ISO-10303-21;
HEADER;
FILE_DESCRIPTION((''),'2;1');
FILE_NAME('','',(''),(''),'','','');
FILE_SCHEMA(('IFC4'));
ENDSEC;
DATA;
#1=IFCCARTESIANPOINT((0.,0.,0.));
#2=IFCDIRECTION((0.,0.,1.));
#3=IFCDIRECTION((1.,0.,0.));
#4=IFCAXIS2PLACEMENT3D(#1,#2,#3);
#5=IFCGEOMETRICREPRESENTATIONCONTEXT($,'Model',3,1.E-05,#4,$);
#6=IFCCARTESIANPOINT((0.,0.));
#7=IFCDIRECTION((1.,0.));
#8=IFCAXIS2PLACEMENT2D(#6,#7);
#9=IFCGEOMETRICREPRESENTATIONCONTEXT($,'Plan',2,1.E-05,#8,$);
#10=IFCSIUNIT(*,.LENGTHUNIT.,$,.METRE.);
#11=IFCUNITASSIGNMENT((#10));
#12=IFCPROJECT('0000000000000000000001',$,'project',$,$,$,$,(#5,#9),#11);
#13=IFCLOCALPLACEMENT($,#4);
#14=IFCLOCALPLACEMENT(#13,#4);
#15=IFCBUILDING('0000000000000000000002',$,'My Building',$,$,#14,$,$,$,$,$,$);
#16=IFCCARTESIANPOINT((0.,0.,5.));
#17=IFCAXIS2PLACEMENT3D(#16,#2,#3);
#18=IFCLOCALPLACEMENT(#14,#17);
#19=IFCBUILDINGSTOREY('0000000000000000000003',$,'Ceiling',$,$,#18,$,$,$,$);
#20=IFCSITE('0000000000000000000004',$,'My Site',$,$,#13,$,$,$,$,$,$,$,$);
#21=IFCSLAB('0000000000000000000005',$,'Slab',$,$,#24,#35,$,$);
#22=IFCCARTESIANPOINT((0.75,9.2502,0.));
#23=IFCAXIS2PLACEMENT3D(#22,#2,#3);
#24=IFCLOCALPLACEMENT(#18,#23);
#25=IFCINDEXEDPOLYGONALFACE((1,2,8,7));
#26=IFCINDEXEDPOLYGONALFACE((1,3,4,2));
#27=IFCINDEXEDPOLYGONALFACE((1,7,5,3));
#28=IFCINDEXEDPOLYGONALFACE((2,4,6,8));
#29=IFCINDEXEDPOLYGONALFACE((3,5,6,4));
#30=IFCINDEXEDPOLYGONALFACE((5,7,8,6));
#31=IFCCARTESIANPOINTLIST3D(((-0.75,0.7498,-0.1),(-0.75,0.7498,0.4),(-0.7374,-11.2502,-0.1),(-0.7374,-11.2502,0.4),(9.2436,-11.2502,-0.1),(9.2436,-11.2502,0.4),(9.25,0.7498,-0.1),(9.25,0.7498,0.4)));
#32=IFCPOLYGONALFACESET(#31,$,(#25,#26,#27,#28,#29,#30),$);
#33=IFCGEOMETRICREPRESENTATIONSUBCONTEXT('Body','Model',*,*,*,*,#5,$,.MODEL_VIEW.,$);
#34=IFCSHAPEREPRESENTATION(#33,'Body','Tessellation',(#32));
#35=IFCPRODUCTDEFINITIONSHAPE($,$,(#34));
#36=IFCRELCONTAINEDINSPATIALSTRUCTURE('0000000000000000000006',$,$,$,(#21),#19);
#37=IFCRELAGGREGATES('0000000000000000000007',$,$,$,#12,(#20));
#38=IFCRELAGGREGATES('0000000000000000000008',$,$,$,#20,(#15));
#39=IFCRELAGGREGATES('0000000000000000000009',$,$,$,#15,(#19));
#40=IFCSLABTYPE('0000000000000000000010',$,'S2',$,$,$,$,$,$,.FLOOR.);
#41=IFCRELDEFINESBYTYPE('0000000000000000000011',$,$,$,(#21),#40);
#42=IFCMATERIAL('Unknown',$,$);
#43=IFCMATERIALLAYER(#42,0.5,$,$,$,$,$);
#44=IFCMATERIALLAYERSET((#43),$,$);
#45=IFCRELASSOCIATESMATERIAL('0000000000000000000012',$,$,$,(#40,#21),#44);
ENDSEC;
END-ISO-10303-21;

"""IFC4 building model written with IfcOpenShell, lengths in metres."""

from ifc_helpers import new_model, si_unit, frame, origin_with_axes, origin_2d_with_axis, place, context, subcontext, project, spatial, indexed_curve, outline, extrude, material, layer, layer_set, layer_usage, type_object, element, save


model = new_model("IFC4")

# Units and contexts
model_context = context("Model", 3, precision=1e-05, world=origin_with_axes())
plan_context = context("Plan", 2, precision=1e-05, world=origin_2d_with_axis())
body_context = subcontext(model_context, "Body", "Model", "MODEL_VIEW")
ifc_project = project(units=[si_unit("LENGTHUNIT", "METRE")], contexts=[model_context, plan_context])

# Site, building, storey
site_placement = place(None, origin_with_axes())
site = spatial("IfcSite", under=ifc_project, at=site_placement, Name="My Site")
building_placement = place(site_placement, origin_with_axes())
building = spatial("IfcBuilding", under=site, at=building_placement, Name="My Building")
storey_placement = place(building_placement, frame((0.0, 0.0, 5.0), z_axis=(0.0, 0.0, 1.0), x_axis=(1.0, 0.0, 0.0)))
storey = spatial("IfcBuildingStorey", under=building, at=storey_placement, Name="Ceiling")

# Slab
ifc_material = material(Name="Unknown")
ifc_layer = layer(ifc_material, 0.5)
ifc_layer_set = layer_set([ifc_layer])
ifc_layer_usage = layer_usage(ifc_layer_set, "AXIS3", "POSITIVE", -0.1)
slab_type = type_object("IfcSlabType", Name="S2", PredefinedType="FLOOR", material=ifc_layer_set)
slab_placement = place(storey_placement, frame((0.75, 9.2502, 0.0), z_axis=(0.0, 0.0, 1.0), x_axis=(1.0, 0.0, 0.0)))
element("IfcSlab", 1, at=slab_placement, inside=storey, type_object=slab_type, material=ifc_layer_usage, Name="Slab", context=body_context, shape_type="SweptSolid", body=[
    extrude(outline(indexed_curve([(-0.7374, -11.2502), (9.2436, -11.2502), (9.25, 0.7498), (-0.75, 0.7498), (-0.7374, -11.2502)])), frame((0.0, 0.0, -0.1), z_axis=(0.0, 0.0, 1.0), x_axis=(1.0, 0.0, 0.0)), (0.0, 0.0, 1.0), 0.5),
])

save(model, "model.ifc")
